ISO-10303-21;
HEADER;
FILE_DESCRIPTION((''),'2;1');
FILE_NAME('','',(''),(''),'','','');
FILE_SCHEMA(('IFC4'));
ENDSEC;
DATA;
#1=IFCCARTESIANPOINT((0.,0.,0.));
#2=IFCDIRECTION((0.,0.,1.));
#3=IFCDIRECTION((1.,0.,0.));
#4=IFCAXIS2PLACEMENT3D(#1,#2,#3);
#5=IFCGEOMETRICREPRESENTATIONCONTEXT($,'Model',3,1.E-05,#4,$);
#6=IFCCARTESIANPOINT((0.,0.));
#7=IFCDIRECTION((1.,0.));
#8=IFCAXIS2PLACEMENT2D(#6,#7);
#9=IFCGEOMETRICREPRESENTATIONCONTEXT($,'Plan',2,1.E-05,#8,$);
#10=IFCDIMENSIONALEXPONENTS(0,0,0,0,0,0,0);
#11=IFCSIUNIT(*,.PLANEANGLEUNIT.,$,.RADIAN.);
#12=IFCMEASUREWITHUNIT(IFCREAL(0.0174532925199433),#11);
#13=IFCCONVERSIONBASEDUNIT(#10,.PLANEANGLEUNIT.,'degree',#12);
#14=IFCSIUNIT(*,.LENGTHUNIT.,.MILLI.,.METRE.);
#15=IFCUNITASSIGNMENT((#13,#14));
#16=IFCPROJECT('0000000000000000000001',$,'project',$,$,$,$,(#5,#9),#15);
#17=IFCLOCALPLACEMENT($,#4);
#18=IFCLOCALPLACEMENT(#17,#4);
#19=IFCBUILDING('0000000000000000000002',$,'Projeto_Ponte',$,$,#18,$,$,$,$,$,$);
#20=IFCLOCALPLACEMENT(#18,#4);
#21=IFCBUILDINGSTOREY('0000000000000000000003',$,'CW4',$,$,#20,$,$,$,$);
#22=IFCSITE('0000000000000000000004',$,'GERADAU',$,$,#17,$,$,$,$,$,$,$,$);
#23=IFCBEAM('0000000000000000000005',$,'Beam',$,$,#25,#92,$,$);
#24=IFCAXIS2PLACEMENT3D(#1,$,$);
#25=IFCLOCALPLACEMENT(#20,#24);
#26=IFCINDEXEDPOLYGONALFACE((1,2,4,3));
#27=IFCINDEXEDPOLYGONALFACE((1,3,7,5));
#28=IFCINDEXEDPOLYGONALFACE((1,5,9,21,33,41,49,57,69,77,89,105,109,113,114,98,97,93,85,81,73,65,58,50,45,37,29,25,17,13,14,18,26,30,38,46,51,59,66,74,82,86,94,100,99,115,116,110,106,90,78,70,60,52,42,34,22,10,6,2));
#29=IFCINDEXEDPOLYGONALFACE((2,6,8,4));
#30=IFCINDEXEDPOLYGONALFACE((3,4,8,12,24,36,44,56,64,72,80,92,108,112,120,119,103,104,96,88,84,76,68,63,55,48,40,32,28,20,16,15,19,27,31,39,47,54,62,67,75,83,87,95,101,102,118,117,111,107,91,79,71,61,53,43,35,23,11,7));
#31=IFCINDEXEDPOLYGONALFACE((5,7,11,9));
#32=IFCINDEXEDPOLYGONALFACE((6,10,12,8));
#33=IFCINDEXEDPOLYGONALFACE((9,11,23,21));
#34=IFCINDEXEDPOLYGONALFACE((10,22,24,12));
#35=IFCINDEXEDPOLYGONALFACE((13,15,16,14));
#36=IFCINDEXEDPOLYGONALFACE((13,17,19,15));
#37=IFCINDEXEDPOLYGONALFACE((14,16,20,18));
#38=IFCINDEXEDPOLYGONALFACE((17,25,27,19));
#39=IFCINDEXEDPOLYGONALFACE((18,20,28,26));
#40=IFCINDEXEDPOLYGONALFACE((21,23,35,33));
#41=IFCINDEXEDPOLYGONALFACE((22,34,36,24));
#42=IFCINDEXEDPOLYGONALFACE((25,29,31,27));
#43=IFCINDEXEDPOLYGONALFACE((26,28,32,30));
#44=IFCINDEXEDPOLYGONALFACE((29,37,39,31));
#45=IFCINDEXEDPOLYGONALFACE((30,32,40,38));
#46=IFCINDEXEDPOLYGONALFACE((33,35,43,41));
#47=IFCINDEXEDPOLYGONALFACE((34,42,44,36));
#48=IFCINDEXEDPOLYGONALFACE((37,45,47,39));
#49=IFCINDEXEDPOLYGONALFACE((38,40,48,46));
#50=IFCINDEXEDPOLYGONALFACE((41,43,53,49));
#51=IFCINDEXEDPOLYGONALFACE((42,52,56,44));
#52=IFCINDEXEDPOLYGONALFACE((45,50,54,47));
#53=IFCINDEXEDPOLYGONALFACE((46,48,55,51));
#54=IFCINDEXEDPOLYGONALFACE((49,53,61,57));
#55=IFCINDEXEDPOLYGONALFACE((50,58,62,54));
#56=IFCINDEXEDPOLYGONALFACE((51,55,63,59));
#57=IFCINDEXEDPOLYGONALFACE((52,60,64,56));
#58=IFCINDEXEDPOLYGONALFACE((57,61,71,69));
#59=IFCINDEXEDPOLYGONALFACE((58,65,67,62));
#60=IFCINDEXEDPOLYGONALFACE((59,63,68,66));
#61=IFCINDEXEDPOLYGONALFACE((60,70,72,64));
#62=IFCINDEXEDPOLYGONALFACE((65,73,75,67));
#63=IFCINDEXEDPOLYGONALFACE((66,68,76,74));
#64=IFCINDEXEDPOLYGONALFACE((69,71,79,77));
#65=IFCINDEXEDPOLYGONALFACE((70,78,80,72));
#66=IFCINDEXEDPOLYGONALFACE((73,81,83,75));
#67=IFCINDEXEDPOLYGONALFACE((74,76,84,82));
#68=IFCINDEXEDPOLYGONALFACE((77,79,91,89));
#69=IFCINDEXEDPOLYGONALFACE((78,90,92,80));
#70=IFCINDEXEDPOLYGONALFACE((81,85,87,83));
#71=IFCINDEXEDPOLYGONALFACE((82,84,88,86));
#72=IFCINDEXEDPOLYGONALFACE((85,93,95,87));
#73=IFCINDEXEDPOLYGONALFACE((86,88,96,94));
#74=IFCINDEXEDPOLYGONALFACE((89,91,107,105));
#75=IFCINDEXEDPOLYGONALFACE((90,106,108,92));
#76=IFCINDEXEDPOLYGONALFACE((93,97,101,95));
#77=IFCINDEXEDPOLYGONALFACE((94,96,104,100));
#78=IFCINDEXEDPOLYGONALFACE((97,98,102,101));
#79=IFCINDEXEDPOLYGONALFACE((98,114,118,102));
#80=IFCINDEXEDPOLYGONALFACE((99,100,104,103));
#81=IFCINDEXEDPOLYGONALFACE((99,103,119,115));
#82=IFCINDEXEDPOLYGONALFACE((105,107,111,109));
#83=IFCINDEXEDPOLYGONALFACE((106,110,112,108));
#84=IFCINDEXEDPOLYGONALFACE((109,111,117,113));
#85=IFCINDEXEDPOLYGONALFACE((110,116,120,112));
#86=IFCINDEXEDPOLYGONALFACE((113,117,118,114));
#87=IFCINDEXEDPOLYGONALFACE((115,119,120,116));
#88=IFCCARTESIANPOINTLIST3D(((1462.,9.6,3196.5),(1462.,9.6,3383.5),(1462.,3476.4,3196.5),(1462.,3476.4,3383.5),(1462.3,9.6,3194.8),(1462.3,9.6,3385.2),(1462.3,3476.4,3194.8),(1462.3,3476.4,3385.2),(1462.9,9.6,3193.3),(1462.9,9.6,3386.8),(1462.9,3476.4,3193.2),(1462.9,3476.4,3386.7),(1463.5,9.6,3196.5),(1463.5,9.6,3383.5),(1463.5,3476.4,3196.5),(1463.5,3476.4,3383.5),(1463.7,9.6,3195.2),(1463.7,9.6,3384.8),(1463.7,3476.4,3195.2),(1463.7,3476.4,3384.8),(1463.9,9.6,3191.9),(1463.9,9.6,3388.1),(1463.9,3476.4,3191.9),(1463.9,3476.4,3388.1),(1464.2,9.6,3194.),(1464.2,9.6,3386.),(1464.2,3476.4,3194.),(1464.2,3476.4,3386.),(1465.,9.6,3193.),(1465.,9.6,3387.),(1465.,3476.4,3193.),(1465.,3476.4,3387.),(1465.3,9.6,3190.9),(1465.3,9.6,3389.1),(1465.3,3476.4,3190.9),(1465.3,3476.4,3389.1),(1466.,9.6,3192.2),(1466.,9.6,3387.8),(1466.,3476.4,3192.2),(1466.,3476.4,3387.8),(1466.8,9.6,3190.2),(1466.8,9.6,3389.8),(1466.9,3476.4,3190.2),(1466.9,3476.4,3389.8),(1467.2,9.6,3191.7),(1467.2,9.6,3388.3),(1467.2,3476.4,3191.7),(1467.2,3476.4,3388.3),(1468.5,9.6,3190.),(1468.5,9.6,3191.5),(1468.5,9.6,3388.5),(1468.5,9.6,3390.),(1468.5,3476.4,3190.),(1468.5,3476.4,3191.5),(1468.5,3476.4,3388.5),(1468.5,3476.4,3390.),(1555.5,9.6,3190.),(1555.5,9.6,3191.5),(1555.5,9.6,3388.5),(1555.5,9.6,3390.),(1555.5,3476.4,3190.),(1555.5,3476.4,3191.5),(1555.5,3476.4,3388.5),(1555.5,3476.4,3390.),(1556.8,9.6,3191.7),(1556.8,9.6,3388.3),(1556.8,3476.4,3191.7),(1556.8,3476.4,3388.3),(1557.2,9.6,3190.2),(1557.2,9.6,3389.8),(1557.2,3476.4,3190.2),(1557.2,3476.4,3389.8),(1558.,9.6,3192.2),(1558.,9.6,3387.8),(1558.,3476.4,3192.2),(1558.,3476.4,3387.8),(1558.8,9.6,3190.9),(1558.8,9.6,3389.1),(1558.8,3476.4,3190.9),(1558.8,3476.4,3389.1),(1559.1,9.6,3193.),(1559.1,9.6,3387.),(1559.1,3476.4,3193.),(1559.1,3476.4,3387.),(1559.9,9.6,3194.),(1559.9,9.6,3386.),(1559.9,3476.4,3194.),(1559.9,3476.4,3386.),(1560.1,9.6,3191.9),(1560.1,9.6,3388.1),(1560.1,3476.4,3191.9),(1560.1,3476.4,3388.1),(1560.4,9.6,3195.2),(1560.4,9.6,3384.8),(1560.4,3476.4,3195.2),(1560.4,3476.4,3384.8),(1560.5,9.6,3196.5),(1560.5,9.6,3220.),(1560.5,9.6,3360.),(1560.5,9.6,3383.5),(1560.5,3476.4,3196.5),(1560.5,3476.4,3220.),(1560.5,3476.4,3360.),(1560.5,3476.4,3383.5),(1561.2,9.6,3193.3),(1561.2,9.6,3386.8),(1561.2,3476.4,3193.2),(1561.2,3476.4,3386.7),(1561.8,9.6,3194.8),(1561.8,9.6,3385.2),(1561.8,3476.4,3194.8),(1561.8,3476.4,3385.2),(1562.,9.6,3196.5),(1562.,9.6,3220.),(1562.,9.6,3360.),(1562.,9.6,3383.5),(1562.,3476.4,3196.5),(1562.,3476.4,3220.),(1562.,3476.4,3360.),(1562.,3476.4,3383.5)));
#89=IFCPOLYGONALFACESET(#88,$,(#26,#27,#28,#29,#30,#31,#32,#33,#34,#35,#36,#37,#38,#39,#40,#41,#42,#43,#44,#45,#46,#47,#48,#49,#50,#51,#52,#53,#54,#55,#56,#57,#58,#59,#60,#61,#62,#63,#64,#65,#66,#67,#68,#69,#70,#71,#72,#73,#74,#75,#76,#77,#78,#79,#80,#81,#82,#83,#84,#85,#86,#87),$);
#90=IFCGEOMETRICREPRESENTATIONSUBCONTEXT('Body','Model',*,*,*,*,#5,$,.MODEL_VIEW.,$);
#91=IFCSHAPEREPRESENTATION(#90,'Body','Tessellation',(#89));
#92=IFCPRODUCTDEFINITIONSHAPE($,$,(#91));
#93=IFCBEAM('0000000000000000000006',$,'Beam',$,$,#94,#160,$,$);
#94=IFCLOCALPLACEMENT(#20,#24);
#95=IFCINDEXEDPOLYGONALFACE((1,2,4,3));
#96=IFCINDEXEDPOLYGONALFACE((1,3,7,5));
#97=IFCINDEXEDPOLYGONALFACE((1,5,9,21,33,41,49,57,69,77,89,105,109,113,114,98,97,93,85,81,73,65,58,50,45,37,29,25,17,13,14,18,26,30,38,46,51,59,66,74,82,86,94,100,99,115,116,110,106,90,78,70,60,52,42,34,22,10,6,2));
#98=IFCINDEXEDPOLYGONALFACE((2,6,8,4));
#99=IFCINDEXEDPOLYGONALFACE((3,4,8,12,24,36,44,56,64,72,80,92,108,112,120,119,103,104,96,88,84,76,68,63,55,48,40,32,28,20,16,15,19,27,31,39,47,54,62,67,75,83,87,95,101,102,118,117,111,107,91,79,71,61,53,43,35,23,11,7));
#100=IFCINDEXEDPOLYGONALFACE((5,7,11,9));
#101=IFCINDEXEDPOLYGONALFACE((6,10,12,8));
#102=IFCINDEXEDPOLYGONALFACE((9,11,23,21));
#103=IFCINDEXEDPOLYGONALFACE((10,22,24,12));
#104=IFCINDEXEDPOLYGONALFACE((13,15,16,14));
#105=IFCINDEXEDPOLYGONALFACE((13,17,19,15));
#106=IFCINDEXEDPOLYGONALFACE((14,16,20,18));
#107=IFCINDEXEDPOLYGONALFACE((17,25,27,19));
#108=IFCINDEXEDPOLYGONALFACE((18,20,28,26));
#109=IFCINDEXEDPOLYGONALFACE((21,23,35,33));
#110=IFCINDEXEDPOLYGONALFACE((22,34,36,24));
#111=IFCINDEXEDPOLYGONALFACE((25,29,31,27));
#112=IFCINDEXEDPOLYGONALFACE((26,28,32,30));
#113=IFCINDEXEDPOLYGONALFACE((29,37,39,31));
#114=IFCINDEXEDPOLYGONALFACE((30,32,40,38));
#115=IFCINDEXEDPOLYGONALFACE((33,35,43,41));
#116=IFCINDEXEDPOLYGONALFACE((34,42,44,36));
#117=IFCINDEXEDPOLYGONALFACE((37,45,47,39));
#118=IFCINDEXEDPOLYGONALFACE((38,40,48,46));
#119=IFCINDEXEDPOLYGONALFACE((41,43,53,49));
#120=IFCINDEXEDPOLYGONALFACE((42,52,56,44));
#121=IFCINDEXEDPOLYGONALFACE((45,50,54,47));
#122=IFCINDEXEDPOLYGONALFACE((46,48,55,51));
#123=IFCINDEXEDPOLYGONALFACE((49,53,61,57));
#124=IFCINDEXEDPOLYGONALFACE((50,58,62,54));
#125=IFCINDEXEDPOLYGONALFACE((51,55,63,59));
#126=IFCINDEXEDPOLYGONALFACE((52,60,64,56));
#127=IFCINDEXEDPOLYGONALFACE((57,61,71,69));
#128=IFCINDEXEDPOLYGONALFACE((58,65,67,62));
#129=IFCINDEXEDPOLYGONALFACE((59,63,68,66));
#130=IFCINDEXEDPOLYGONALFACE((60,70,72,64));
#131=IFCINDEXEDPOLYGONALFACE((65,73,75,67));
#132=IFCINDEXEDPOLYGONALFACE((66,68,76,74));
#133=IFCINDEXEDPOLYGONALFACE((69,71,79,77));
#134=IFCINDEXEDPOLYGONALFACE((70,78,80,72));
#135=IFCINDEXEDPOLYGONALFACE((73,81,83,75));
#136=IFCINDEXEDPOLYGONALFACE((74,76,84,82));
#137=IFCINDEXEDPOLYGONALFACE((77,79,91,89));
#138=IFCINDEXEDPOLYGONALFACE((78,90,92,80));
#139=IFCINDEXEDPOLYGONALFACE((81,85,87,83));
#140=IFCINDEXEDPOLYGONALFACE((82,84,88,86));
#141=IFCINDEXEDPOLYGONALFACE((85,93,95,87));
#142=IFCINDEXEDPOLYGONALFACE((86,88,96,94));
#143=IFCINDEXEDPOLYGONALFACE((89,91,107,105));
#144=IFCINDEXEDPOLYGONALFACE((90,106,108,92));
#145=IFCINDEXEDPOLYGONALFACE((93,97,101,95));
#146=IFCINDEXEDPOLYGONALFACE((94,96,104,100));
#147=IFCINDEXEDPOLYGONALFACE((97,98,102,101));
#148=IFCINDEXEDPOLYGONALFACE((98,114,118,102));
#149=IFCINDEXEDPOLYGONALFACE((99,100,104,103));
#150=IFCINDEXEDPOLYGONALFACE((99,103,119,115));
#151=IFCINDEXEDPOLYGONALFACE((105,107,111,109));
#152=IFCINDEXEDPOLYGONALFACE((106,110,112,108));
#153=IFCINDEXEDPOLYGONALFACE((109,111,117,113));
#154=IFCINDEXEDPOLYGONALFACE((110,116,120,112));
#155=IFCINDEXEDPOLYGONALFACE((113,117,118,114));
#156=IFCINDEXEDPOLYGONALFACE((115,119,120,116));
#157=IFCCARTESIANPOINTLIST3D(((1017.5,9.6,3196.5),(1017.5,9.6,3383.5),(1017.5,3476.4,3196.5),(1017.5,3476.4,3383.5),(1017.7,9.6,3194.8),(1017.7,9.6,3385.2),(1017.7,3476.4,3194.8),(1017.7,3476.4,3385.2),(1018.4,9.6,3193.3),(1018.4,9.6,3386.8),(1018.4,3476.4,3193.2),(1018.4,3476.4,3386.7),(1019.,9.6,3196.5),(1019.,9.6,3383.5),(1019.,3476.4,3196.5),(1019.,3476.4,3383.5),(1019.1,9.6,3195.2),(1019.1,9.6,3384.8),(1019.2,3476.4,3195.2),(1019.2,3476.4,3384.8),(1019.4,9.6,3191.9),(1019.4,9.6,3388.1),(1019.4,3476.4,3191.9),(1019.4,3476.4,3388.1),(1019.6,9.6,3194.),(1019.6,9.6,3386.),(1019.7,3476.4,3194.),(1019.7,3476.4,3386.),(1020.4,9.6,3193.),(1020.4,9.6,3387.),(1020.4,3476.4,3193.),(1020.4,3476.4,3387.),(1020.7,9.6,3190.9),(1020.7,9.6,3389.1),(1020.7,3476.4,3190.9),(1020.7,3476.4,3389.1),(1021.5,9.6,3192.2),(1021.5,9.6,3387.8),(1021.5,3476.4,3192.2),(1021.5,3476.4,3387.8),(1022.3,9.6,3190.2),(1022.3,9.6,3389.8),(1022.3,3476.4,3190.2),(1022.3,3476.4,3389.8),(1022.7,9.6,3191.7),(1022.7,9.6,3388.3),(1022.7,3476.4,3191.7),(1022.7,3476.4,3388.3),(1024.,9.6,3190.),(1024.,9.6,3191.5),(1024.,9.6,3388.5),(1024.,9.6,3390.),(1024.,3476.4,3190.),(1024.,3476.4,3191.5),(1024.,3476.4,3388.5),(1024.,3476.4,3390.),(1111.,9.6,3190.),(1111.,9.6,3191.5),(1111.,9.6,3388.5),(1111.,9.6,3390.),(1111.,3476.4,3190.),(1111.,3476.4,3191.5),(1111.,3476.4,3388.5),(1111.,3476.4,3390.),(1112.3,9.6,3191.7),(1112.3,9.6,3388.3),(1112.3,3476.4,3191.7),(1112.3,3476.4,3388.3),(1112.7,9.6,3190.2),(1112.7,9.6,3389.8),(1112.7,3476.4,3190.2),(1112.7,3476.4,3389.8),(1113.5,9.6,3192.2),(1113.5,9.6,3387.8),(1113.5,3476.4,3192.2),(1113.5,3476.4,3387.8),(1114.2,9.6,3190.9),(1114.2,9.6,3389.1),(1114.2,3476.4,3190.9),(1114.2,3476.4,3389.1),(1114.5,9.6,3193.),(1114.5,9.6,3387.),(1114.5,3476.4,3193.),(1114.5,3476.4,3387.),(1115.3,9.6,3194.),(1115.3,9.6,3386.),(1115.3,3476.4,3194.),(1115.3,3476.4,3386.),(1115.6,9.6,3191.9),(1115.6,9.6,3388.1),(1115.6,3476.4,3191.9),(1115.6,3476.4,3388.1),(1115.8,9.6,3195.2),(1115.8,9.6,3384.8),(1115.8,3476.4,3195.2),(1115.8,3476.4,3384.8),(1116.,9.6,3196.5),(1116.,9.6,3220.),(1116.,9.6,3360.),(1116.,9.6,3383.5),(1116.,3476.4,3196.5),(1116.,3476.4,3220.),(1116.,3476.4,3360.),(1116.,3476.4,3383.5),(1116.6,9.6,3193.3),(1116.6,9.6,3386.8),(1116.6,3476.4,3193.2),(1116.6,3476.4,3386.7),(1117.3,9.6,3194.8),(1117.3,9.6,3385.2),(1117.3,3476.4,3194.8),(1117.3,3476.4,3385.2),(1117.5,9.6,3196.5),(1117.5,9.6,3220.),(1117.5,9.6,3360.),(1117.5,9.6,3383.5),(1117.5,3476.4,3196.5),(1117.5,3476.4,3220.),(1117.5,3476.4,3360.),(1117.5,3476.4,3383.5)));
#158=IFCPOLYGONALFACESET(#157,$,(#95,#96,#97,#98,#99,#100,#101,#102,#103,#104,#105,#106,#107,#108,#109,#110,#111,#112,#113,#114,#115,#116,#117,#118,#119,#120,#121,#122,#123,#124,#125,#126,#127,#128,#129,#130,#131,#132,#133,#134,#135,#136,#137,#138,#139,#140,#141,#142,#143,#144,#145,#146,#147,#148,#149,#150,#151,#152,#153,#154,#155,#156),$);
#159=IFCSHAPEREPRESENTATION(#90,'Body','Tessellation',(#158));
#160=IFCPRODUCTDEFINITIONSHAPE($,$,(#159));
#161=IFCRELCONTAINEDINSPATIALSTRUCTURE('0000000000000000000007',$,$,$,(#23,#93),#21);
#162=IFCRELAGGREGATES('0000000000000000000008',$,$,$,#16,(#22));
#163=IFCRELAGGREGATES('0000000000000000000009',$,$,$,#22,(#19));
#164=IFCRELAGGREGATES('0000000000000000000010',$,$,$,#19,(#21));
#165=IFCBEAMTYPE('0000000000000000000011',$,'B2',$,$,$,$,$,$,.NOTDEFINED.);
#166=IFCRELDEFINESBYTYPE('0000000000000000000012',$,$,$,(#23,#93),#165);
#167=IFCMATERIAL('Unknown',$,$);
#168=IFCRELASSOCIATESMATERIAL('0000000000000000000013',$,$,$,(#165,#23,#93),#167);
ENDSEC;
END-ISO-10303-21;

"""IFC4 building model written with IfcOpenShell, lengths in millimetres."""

from ifc_helpers import new_model, entity, si_unit, converted_unit, frame, origin_with_axes, origin_2d_with_axis, place, context, subcontext, project, spatial, c_section, extrude, material, material_profile, profile_set, profile_usage, type_object, element, save


model = new_model("IFC4")

# Units and contexts
model_context = context("Model", 3, precision=1e-05, world=origin_with_axes())
plan_context = context("Plan", 2, precision=1e-05, world=origin_2d_with_axis())
body_context = subcontext(model_context, "Body", "Model", "MODEL_VIEW")
ifc_project = project(units=[converted_unit("PLANEANGLEUNIT", "degree", entity("IfcReal", 0.0174532925199433), si_unit("PLANEANGLEUNIT", "RADIAN"), dimensions=[0, 0, 0, 0, 0, 0, 0]), si_unit("LENGTHUNIT", "METRE", prefix="MILLI")], contexts=[model_context, plan_context])

# Site, building, storey
site_placement = place(None, origin_with_axes())
site = spatial("IfcSite", under=ifc_project, at=site_placement, Name="GERADAU")
building_placement = place(site_placement, origin_with_axes())
building = spatial("IfcBuilding", under=site, at=building_placement, Name="Projeto_Ponte")
storey_placement = place(building_placement, origin_with_axes())
storey = spatial("IfcBuildingStorey", under=building, at=storey_placement, Name="CW4")

# Beams
ifc_material = material(Name="Unknown")
ifc_material_profile = material_profile(ifc_material, c_section(Depth=200.0, Width=100.0, WallThickness=1.5, Girth=30.0, InternalFilletRadius=5.0))
ifc_profile_set = profile_set([ifc_material_profile])
ifc_profile_usage_1 = profile_usage(ifc_profile_set, cardinal=5)
beam_type = type_object("IfcBeamType", Name="B2", PredefinedType="NOTDEFINED", material=ifc_profile_set)
beam_1_placement = place(storey_placement, frame((1512.0, 3476.4, 3290.0), z_axis=(0.0, -1.0, 0.0), x_axis=(1.0, 0.0, 0.0)))
element("IfcBeam", 1, at=beam_1_placement, inside=storey, type_object=beam_type, material=ifc_profile_usage_1, Name="Beam", context=body_context, shape_type="SweptSolid", body=[
    extrude(c_section(Depth=200.0, Width=100.0, WallThickness=1.5, Girth=30.0, InternalFilletRadius=5.0), origin_with_axes(), (0.0, 0.0, 1.0), 3466.8),
])
ifc_profile_usage_2 = profile_usage(ifc_profile_set, cardinal=5)
beam_2_placement = place(storey_placement, frame((1067.5, 3476.4, 3290.0), z_axis=(0.0, -1.0, 0.0), x_axis=(1.0, 0.0, 0.0)))
element("IfcBeam", 2, at=beam_2_placement, inside=storey, type_object=beam_type, material=ifc_profile_usage_2, Name="Beam", context=body_context, shape_type="SweptSolid", body=[
    extrude(c_section(Depth=200.0, Width=100.0, WallThickness=1.5, Girth=30.0, InternalFilletRadius=5.0), origin_with_axes(), (0.0, 0.0, 1.0), 3466.8),
])

save(model, "model.ifc")
